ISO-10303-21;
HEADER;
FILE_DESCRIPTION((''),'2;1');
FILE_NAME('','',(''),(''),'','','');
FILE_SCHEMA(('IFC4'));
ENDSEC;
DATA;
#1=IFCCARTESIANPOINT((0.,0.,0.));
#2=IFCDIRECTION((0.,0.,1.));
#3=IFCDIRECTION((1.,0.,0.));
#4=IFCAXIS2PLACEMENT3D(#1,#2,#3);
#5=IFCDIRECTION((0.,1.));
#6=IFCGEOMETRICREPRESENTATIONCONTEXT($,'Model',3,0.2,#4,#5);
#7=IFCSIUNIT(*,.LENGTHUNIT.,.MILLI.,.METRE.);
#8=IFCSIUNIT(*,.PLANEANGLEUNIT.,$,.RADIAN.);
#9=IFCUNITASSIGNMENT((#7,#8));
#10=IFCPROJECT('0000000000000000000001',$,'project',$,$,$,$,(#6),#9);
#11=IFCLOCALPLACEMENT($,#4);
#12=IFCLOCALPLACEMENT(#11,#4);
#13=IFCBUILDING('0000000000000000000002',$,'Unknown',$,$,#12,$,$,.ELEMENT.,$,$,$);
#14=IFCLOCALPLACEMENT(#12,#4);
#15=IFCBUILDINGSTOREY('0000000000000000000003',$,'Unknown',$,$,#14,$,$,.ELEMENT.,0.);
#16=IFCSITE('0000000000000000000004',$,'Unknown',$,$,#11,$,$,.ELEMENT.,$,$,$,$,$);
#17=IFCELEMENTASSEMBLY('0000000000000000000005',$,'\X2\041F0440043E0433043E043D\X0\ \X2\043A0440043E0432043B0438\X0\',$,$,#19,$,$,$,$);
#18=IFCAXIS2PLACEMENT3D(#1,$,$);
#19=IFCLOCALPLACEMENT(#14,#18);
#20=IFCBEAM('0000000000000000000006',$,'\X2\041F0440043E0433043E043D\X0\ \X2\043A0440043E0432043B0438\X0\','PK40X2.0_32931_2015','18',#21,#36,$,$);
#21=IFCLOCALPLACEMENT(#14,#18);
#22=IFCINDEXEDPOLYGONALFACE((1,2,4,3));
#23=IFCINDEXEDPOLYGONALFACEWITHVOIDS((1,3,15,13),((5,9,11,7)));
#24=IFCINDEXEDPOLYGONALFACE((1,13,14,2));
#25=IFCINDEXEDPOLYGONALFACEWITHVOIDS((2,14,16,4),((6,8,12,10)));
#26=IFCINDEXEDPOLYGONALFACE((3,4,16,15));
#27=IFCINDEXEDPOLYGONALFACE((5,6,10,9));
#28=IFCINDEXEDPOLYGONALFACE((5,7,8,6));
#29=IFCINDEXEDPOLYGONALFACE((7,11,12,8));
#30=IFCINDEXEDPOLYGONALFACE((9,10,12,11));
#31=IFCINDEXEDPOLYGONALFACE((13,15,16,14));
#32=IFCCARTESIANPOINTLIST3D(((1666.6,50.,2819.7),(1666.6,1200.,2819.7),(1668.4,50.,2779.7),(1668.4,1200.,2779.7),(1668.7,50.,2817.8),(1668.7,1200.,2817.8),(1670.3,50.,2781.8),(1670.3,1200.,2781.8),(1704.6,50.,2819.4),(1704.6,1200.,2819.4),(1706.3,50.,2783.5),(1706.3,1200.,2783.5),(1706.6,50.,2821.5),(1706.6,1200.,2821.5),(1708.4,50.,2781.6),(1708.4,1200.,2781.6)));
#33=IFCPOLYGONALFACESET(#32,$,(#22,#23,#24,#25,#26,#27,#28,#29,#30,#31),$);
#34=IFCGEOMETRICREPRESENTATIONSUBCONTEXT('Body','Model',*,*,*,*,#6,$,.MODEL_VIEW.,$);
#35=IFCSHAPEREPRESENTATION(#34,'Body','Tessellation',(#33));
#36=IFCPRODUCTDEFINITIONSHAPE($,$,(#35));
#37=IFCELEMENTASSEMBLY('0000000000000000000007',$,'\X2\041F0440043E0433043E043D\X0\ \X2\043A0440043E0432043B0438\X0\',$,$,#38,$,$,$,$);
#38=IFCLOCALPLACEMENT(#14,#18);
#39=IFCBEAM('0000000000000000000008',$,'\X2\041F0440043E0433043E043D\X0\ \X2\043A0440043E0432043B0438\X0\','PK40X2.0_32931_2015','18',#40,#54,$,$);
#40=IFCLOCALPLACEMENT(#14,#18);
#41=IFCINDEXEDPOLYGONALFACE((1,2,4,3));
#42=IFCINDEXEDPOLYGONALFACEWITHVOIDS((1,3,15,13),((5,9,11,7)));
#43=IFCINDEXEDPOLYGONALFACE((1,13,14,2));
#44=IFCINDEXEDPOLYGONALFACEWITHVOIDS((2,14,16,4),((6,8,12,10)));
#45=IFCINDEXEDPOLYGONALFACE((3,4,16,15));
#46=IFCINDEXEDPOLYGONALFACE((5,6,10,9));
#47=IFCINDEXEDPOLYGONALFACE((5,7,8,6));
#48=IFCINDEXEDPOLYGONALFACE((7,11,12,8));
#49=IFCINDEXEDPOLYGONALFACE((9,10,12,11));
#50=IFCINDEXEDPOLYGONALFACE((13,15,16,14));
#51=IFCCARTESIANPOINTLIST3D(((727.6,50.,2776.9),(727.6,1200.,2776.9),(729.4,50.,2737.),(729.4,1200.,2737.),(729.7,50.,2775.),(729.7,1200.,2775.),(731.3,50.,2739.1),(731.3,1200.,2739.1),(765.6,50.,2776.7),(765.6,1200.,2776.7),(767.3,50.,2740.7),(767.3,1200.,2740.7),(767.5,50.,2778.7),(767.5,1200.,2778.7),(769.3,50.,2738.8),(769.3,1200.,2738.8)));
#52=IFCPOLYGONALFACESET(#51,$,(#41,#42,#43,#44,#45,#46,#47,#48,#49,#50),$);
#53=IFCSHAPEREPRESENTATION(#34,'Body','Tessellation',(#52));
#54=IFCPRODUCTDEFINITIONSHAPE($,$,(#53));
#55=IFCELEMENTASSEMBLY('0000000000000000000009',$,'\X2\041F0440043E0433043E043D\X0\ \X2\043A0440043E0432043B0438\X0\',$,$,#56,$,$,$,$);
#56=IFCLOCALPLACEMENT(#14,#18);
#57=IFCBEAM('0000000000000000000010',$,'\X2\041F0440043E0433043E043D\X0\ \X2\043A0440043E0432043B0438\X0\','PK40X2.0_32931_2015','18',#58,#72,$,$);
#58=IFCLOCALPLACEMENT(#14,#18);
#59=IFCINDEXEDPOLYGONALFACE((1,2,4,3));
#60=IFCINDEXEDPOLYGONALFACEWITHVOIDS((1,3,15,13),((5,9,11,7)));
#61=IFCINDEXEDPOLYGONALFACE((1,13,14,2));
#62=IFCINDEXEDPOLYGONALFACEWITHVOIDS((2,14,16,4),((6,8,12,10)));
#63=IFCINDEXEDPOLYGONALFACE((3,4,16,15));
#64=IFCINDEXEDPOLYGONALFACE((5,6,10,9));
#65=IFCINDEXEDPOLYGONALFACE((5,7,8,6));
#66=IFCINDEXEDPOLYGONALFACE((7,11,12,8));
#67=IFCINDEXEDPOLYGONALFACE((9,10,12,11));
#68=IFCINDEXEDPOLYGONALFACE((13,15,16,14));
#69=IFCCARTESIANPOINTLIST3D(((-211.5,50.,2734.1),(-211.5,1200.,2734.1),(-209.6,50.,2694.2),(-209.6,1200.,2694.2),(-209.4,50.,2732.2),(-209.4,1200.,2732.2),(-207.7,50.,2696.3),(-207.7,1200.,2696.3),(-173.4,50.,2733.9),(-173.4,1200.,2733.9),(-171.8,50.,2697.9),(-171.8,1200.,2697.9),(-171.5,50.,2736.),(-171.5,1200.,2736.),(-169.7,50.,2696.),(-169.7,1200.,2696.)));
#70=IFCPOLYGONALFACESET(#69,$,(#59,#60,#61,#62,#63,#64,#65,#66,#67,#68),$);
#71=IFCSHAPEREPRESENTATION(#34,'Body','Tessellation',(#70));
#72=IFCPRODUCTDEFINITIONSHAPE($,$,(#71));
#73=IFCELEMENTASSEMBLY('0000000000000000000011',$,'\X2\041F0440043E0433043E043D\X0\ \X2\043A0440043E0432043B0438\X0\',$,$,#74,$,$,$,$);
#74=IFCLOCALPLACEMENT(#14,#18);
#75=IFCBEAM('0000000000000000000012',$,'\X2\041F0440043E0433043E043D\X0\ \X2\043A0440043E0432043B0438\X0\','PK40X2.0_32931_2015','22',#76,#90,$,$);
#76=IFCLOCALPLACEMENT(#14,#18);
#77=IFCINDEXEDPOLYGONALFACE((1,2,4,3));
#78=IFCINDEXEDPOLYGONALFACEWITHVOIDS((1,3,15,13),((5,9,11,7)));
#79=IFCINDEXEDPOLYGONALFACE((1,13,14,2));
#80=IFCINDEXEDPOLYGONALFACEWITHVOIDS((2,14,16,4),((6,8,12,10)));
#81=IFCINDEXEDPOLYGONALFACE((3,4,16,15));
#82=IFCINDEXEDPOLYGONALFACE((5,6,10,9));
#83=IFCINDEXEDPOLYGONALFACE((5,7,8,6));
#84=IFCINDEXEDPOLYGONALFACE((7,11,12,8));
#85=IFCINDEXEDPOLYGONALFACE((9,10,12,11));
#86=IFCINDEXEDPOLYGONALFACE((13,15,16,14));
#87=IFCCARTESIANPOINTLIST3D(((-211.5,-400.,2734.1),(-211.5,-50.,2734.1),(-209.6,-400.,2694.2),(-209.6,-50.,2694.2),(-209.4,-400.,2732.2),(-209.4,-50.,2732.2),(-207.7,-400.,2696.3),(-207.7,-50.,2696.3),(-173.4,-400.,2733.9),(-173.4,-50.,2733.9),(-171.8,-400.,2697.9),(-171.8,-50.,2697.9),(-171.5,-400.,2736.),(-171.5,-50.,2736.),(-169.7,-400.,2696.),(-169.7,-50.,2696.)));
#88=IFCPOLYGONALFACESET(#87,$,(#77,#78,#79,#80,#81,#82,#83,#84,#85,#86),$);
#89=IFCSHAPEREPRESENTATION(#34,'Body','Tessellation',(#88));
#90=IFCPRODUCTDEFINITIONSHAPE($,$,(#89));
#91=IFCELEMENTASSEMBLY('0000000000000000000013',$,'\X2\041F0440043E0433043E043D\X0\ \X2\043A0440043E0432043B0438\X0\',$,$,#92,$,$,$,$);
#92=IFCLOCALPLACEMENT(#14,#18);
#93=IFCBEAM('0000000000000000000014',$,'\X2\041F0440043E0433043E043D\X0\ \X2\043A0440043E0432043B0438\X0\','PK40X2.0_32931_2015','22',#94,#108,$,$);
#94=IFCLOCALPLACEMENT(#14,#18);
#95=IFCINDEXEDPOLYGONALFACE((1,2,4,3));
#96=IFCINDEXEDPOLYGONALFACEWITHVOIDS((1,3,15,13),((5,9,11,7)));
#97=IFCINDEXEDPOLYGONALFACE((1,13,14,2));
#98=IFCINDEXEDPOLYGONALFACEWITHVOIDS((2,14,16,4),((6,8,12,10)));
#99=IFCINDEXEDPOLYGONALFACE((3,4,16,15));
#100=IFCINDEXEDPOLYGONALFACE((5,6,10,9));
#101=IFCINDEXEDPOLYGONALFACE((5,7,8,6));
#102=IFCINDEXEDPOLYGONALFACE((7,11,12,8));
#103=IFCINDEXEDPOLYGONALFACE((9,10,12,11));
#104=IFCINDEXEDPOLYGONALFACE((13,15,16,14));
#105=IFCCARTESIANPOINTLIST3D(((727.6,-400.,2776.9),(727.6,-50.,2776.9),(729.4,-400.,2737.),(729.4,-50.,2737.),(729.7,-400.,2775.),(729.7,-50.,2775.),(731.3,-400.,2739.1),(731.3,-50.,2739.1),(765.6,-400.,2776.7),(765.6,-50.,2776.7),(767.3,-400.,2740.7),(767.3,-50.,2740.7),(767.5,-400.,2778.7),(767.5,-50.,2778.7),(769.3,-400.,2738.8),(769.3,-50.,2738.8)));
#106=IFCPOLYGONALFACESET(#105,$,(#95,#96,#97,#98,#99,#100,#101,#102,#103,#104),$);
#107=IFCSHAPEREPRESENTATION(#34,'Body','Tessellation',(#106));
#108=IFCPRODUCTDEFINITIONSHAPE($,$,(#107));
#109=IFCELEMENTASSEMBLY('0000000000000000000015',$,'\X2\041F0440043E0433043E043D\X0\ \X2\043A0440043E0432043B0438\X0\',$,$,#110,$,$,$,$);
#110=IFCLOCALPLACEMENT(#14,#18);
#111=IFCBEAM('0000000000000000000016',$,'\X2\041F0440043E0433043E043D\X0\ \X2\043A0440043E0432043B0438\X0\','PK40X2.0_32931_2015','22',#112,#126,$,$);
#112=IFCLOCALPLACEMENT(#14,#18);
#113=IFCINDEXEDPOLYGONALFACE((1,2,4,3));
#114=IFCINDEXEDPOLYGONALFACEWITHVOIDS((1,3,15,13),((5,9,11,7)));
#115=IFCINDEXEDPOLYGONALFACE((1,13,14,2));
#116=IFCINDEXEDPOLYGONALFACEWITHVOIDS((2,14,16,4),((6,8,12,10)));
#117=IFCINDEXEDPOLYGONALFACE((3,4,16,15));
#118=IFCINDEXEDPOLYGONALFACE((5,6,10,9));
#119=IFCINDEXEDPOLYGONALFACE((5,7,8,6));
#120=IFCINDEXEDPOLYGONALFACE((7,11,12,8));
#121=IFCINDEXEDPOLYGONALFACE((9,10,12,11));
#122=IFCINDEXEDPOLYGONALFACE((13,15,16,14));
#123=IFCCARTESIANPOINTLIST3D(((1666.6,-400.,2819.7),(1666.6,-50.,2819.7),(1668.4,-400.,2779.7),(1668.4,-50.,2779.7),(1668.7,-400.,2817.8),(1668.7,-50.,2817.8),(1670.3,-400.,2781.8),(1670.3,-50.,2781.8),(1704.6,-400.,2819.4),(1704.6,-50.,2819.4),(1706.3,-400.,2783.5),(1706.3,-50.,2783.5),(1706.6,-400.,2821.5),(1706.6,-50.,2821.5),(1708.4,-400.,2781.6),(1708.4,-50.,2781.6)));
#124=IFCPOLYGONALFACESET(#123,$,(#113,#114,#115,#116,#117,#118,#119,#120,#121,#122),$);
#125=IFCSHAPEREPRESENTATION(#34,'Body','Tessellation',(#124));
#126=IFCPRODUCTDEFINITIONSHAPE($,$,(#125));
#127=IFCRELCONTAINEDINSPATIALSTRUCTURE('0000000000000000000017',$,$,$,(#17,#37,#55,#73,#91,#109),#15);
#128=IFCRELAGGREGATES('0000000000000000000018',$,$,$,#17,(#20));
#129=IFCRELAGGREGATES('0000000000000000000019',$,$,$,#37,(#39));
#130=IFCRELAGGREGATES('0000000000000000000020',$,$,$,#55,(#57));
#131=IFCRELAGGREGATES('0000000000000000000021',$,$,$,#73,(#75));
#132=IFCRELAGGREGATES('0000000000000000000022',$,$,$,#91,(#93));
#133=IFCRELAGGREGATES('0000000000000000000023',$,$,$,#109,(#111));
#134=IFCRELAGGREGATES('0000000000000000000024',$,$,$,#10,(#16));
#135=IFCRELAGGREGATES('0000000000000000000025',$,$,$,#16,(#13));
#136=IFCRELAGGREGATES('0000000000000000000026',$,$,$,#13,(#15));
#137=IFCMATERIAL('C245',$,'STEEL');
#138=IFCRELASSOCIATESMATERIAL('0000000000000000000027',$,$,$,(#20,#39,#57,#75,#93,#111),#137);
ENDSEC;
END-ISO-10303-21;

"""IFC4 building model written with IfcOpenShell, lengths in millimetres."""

from ifc_helpers import new_model, si_unit, direction, frame, origin_with_axes, place, context, subcontext, project, spatial, line, indexed_curve, outline, extrude, material, element, aggregate, save


model = new_model("IFC4")

# Units and contexts
model_context = context("Model", 3, precision=0.2, world=origin_with_axes(), true_north=direction((0.0, 1.0)))
body_context = subcontext(model_context, "Body", "Model", "MODEL_VIEW")
ifc_project = project(units=[si_unit("LENGTHUNIT", "METRE", prefix="MILLI"), si_unit("PLANEANGLEUNIT", "RADIAN")], contexts=[model_context])

# Site, building, storey
site_placement = place(None, origin_with_axes())
site = spatial("IfcSite", under=ifc_project, at=site_placement, Name="Unknown", CompositionType="ELEMENT")
building_placement = place(site_placement, origin_with_axes())
building = spatial("IfcBuilding", under=site, at=building_placement, Name="Unknown", CompositionType="ELEMENT")
storey_placement = place(building_placement, origin_with_axes())
storey = spatial("IfcBuildingStorey", under=building, at=storey_placement, Name="Unknown", CompositionType="ELEMENT", Elevation=0.0)

# Shared definitions
ifc_material = material(Name="C245", Category="STEEL")

# Element assemblies, beams
assembly_1_placement = place(storey_placement, frame((1687.5, 1200.0, 2800.6), z_axis=(-0.998964, 0.0, -0.045508), x_axis=(0.0, -1.0, 0.0)))
assembly_1 = element("IfcElementAssembly", 1, at=assembly_1_placement, inside=storey, Name="Прогон кровли")
beam_1_placement = place(assembly_1_placement, origin_with_axes())
beam_1 = element("IfcBeam", 2, at=beam_1_placement, material=ifc_material, Name="Прогон кровли", Description="PK40X2.0_32931_2015", ObjectType="18", context=body_context, shape_type="SolidModel", body=[
    extrude(outline(indexed_curve([(-20.0, -20.0), (20.0, -20.0), (20.0, 20.0), (-20.0, 20.0)], segments=[line(1, 2, 3, 4, 1)]), holes=[indexed_curve([(-18.0, -18.0), (-18.0, 18.0), (18.0, 18.0), (18.0, -18.0)], segments=[line(1, 2, 3, 4, 1)])]), frame((0.0, 0.0, 0.0), z_axis=(-1.0, 0.0, 0.0), x_axis=(0.0, 0.0, 1.0)), (0.0, 0.0, -1.0), 1150.0),
])
aggregate(assembly_1, [beam_1])
assembly_2_placement = place(storey_placement, frame((748.5, 1200.0, 2757.9), z_axis=(-0.998964, 0.0, -0.045508), x_axis=(0.0, -1.0, 0.0)))
assembly_2 = element("IfcElementAssembly", 3, at=assembly_2_placement, inside=storey, Name="Прогон кровли")
beam_2_placement = place(assembly_2_placement, origin_with_axes())
beam_2 = element("IfcBeam", 4, at=beam_2_placement, material=ifc_material, Name="Прогон кровли", Description="PK40X2.0_32931_2015", ObjectType="18", context=body_context, shape_type="SolidModel", body=[
    extrude(outline(indexed_curve([(-20.0, -20.0), (20.0, -20.0), (20.0, 20.0), (-20.0, 20.0)], segments=[line(1, 2, 3, 4, 1)]), holes=[indexed_curve([(-18.0, -18.0), (-18.0, 18.0), (18.0, 18.0), (18.0, -18.0)], segments=[line(1, 2, 3, 4, 1)])]), frame((0.0, 0.0, 0.0), z_axis=(-1.0, 0.0, 0.0), x_axis=(0.0, 0.0, 1.0)), (0.0, 0.0, -1.0), 1150.0),
])
aggregate(assembly_2, [beam_2])
assembly_3_placement = place(storey_placement, frame((-190.6, 1200.0, 2715.1), z_axis=(-0.998964, 0.0, -0.045508), x_axis=(0.0, -1.0, 0.0)))
assembly_3 = element("IfcElementAssembly", 5, at=assembly_3_placement, inside=storey, Name="Прогон кровли")
beam_3_placement = place(assembly_3_placement, origin_with_axes())
beam_3 = element("IfcBeam", 6, at=beam_3_placement, material=ifc_material, Name="Прогон кровли", Description="PK40X2.0_32931_2015", ObjectType="18", context=body_context, shape_type="SolidModel", body=[
    extrude(outline(indexed_curve([(-20.0, -20.0), (20.0, -20.0), (20.0, 20.0), (-20.0, 20.0)], segments=[line(1, 2, 3, 4, 1)]), holes=[indexed_curve([(-18.0, -18.0), (-18.0, 18.0), (18.0, 18.0), (18.0, -18.0)], segments=[line(1, 2, 3, 4, 1)])]), frame((0.0, 0.0, 0.0), z_axis=(-1.0, 0.0, 0.0), x_axis=(0.0, 0.0, 1.0)), (0.0, 0.0, -1.0), 1150.0),
])
aggregate(assembly_3, [beam_3])
assembly_4_placement = place(storey_placement, frame((-190.6, -50.0, 2715.1), z_axis=(-0.998964, 0.0, -0.045508), x_axis=(0.0, -1.0, 0.0)))
assembly_4 = element("IfcElementAssembly", 7, at=assembly_4_placement, inside=storey, Name="Прогон кровли")
beam_4_placement = place(assembly_4_placement, origin_with_axes())
beam_4 = element("IfcBeam", 8, at=beam_4_placement, material=ifc_material, Name="Прогон кровли", Description="PK40X2.0_32931_2015", ObjectType="22", context=body_context, shape_type="SolidModel", body=[
    extrude(outline(indexed_curve([(-20.0, -20.0), (20.0, -20.0), (20.0, 20.0), (-20.0, 20.0)], segments=[line(1, 2, 3, 4, 1)]), holes=[indexed_curve([(-18.0, -18.0), (-18.0, 18.0), (18.0, 18.0), (18.0, -18.0)], segments=[line(1, 2, 3, 4, 1)])]), frame((0.0, 0.0, 0.0), z_axis=(-1.0, 0.0, 0.0), x_axis=(0.0, 0.0, 1.0)), (0.0, 0.0, -1.0), 350.0),
])
aggregate(assembly_4, [beam_4])
assembly_5_placement = place(storey_placement, frame((748.5, -50.0, 2757.9), z_axis=(-0.998964, 0.0, -0.045508), x_axis=(0.0, -1.0, 0.0)))
assembly_5 = element("IfcElementAssembly", 9, at=assembly_5_placement, inside=storey, Name="Прогон кровли")
beam_5_placement = place(assembly_5_placement, origin_with_axes())
beam_5 = element("IfcBeam", 10, at=beam_5_placement, material=ifc_material, Name="Прогон кровли", Description="PK40X2.0_32931_2015", ObjectType="22", context=body_context, shape_type="SolidModel", body=[
    extrude(outline(indexed_curve([(-20.0, -20.0), (20.0, -20.0), (20.0, 20.0), (-20.0, 20.0)], segments=[line(1, 2, 3, 4, 1)]), holes=[indexed_curve([(-18.0, -18.0), (-18.0, 18.0), (18.0, 18.0), (18.0, -18.0)], segments=[line(1, 2, 3, 4, 1)])]), frame((0.0, 0.0, 0.0), z_axis=(-1.0, 0.0, 0.0), x_axis=(0.0, 0.0, 1.0)), (0.0, 0.0, -1.0), 350.0),
])
aggregate(assembly_5, [beam_5])
assembly_6_placement = place(storey_placement, frame((1687.5, -50.0, 2800.6), z_axis=(-0.998964, 0.0, -0.045508), x_axis=(0.0, -1.0, 0.0)))
assembly_6 = element("IfcElementAssembly", 11, at=assembly_6_placement, inside=storey, Name="Прогон кровли")
beam_6_placement = place(assembly_6_placement, origin_with_axes())
beam_6 = element("IfcBeam", 12, at=beam_6_placement, material=ifc_material, Name="Прогон кровли", Description="PK40X2.0_32931_2015", ObjectType="22", context=body_context, shape_type="SolidModel", body=[
    extrude(outline(indexed_curve([(-20.0, -20.0), (20.0, -20.0), (20.0, 20.0), (-20.0, 20.0)], segments=[line(1, 2, 3, 4, 1)]), holes=[indexed_curve([(-18.0, -18.0), (-18.0, 18.0), (18.0, 18.0), (18.0, -18.0)], segments=[line(1, 2, 3, 4, 1)])]), frame((0.0, 0.0, 0.0), z_axis=(-1.0, 0.0, 0.0), x_axis=(0.0, 0.0, 1.0)), (0.0, 0.0, -1.0), 350.0),
])
aggregate(assembly_6, [beam_6])

save(model, "model.ifc")
